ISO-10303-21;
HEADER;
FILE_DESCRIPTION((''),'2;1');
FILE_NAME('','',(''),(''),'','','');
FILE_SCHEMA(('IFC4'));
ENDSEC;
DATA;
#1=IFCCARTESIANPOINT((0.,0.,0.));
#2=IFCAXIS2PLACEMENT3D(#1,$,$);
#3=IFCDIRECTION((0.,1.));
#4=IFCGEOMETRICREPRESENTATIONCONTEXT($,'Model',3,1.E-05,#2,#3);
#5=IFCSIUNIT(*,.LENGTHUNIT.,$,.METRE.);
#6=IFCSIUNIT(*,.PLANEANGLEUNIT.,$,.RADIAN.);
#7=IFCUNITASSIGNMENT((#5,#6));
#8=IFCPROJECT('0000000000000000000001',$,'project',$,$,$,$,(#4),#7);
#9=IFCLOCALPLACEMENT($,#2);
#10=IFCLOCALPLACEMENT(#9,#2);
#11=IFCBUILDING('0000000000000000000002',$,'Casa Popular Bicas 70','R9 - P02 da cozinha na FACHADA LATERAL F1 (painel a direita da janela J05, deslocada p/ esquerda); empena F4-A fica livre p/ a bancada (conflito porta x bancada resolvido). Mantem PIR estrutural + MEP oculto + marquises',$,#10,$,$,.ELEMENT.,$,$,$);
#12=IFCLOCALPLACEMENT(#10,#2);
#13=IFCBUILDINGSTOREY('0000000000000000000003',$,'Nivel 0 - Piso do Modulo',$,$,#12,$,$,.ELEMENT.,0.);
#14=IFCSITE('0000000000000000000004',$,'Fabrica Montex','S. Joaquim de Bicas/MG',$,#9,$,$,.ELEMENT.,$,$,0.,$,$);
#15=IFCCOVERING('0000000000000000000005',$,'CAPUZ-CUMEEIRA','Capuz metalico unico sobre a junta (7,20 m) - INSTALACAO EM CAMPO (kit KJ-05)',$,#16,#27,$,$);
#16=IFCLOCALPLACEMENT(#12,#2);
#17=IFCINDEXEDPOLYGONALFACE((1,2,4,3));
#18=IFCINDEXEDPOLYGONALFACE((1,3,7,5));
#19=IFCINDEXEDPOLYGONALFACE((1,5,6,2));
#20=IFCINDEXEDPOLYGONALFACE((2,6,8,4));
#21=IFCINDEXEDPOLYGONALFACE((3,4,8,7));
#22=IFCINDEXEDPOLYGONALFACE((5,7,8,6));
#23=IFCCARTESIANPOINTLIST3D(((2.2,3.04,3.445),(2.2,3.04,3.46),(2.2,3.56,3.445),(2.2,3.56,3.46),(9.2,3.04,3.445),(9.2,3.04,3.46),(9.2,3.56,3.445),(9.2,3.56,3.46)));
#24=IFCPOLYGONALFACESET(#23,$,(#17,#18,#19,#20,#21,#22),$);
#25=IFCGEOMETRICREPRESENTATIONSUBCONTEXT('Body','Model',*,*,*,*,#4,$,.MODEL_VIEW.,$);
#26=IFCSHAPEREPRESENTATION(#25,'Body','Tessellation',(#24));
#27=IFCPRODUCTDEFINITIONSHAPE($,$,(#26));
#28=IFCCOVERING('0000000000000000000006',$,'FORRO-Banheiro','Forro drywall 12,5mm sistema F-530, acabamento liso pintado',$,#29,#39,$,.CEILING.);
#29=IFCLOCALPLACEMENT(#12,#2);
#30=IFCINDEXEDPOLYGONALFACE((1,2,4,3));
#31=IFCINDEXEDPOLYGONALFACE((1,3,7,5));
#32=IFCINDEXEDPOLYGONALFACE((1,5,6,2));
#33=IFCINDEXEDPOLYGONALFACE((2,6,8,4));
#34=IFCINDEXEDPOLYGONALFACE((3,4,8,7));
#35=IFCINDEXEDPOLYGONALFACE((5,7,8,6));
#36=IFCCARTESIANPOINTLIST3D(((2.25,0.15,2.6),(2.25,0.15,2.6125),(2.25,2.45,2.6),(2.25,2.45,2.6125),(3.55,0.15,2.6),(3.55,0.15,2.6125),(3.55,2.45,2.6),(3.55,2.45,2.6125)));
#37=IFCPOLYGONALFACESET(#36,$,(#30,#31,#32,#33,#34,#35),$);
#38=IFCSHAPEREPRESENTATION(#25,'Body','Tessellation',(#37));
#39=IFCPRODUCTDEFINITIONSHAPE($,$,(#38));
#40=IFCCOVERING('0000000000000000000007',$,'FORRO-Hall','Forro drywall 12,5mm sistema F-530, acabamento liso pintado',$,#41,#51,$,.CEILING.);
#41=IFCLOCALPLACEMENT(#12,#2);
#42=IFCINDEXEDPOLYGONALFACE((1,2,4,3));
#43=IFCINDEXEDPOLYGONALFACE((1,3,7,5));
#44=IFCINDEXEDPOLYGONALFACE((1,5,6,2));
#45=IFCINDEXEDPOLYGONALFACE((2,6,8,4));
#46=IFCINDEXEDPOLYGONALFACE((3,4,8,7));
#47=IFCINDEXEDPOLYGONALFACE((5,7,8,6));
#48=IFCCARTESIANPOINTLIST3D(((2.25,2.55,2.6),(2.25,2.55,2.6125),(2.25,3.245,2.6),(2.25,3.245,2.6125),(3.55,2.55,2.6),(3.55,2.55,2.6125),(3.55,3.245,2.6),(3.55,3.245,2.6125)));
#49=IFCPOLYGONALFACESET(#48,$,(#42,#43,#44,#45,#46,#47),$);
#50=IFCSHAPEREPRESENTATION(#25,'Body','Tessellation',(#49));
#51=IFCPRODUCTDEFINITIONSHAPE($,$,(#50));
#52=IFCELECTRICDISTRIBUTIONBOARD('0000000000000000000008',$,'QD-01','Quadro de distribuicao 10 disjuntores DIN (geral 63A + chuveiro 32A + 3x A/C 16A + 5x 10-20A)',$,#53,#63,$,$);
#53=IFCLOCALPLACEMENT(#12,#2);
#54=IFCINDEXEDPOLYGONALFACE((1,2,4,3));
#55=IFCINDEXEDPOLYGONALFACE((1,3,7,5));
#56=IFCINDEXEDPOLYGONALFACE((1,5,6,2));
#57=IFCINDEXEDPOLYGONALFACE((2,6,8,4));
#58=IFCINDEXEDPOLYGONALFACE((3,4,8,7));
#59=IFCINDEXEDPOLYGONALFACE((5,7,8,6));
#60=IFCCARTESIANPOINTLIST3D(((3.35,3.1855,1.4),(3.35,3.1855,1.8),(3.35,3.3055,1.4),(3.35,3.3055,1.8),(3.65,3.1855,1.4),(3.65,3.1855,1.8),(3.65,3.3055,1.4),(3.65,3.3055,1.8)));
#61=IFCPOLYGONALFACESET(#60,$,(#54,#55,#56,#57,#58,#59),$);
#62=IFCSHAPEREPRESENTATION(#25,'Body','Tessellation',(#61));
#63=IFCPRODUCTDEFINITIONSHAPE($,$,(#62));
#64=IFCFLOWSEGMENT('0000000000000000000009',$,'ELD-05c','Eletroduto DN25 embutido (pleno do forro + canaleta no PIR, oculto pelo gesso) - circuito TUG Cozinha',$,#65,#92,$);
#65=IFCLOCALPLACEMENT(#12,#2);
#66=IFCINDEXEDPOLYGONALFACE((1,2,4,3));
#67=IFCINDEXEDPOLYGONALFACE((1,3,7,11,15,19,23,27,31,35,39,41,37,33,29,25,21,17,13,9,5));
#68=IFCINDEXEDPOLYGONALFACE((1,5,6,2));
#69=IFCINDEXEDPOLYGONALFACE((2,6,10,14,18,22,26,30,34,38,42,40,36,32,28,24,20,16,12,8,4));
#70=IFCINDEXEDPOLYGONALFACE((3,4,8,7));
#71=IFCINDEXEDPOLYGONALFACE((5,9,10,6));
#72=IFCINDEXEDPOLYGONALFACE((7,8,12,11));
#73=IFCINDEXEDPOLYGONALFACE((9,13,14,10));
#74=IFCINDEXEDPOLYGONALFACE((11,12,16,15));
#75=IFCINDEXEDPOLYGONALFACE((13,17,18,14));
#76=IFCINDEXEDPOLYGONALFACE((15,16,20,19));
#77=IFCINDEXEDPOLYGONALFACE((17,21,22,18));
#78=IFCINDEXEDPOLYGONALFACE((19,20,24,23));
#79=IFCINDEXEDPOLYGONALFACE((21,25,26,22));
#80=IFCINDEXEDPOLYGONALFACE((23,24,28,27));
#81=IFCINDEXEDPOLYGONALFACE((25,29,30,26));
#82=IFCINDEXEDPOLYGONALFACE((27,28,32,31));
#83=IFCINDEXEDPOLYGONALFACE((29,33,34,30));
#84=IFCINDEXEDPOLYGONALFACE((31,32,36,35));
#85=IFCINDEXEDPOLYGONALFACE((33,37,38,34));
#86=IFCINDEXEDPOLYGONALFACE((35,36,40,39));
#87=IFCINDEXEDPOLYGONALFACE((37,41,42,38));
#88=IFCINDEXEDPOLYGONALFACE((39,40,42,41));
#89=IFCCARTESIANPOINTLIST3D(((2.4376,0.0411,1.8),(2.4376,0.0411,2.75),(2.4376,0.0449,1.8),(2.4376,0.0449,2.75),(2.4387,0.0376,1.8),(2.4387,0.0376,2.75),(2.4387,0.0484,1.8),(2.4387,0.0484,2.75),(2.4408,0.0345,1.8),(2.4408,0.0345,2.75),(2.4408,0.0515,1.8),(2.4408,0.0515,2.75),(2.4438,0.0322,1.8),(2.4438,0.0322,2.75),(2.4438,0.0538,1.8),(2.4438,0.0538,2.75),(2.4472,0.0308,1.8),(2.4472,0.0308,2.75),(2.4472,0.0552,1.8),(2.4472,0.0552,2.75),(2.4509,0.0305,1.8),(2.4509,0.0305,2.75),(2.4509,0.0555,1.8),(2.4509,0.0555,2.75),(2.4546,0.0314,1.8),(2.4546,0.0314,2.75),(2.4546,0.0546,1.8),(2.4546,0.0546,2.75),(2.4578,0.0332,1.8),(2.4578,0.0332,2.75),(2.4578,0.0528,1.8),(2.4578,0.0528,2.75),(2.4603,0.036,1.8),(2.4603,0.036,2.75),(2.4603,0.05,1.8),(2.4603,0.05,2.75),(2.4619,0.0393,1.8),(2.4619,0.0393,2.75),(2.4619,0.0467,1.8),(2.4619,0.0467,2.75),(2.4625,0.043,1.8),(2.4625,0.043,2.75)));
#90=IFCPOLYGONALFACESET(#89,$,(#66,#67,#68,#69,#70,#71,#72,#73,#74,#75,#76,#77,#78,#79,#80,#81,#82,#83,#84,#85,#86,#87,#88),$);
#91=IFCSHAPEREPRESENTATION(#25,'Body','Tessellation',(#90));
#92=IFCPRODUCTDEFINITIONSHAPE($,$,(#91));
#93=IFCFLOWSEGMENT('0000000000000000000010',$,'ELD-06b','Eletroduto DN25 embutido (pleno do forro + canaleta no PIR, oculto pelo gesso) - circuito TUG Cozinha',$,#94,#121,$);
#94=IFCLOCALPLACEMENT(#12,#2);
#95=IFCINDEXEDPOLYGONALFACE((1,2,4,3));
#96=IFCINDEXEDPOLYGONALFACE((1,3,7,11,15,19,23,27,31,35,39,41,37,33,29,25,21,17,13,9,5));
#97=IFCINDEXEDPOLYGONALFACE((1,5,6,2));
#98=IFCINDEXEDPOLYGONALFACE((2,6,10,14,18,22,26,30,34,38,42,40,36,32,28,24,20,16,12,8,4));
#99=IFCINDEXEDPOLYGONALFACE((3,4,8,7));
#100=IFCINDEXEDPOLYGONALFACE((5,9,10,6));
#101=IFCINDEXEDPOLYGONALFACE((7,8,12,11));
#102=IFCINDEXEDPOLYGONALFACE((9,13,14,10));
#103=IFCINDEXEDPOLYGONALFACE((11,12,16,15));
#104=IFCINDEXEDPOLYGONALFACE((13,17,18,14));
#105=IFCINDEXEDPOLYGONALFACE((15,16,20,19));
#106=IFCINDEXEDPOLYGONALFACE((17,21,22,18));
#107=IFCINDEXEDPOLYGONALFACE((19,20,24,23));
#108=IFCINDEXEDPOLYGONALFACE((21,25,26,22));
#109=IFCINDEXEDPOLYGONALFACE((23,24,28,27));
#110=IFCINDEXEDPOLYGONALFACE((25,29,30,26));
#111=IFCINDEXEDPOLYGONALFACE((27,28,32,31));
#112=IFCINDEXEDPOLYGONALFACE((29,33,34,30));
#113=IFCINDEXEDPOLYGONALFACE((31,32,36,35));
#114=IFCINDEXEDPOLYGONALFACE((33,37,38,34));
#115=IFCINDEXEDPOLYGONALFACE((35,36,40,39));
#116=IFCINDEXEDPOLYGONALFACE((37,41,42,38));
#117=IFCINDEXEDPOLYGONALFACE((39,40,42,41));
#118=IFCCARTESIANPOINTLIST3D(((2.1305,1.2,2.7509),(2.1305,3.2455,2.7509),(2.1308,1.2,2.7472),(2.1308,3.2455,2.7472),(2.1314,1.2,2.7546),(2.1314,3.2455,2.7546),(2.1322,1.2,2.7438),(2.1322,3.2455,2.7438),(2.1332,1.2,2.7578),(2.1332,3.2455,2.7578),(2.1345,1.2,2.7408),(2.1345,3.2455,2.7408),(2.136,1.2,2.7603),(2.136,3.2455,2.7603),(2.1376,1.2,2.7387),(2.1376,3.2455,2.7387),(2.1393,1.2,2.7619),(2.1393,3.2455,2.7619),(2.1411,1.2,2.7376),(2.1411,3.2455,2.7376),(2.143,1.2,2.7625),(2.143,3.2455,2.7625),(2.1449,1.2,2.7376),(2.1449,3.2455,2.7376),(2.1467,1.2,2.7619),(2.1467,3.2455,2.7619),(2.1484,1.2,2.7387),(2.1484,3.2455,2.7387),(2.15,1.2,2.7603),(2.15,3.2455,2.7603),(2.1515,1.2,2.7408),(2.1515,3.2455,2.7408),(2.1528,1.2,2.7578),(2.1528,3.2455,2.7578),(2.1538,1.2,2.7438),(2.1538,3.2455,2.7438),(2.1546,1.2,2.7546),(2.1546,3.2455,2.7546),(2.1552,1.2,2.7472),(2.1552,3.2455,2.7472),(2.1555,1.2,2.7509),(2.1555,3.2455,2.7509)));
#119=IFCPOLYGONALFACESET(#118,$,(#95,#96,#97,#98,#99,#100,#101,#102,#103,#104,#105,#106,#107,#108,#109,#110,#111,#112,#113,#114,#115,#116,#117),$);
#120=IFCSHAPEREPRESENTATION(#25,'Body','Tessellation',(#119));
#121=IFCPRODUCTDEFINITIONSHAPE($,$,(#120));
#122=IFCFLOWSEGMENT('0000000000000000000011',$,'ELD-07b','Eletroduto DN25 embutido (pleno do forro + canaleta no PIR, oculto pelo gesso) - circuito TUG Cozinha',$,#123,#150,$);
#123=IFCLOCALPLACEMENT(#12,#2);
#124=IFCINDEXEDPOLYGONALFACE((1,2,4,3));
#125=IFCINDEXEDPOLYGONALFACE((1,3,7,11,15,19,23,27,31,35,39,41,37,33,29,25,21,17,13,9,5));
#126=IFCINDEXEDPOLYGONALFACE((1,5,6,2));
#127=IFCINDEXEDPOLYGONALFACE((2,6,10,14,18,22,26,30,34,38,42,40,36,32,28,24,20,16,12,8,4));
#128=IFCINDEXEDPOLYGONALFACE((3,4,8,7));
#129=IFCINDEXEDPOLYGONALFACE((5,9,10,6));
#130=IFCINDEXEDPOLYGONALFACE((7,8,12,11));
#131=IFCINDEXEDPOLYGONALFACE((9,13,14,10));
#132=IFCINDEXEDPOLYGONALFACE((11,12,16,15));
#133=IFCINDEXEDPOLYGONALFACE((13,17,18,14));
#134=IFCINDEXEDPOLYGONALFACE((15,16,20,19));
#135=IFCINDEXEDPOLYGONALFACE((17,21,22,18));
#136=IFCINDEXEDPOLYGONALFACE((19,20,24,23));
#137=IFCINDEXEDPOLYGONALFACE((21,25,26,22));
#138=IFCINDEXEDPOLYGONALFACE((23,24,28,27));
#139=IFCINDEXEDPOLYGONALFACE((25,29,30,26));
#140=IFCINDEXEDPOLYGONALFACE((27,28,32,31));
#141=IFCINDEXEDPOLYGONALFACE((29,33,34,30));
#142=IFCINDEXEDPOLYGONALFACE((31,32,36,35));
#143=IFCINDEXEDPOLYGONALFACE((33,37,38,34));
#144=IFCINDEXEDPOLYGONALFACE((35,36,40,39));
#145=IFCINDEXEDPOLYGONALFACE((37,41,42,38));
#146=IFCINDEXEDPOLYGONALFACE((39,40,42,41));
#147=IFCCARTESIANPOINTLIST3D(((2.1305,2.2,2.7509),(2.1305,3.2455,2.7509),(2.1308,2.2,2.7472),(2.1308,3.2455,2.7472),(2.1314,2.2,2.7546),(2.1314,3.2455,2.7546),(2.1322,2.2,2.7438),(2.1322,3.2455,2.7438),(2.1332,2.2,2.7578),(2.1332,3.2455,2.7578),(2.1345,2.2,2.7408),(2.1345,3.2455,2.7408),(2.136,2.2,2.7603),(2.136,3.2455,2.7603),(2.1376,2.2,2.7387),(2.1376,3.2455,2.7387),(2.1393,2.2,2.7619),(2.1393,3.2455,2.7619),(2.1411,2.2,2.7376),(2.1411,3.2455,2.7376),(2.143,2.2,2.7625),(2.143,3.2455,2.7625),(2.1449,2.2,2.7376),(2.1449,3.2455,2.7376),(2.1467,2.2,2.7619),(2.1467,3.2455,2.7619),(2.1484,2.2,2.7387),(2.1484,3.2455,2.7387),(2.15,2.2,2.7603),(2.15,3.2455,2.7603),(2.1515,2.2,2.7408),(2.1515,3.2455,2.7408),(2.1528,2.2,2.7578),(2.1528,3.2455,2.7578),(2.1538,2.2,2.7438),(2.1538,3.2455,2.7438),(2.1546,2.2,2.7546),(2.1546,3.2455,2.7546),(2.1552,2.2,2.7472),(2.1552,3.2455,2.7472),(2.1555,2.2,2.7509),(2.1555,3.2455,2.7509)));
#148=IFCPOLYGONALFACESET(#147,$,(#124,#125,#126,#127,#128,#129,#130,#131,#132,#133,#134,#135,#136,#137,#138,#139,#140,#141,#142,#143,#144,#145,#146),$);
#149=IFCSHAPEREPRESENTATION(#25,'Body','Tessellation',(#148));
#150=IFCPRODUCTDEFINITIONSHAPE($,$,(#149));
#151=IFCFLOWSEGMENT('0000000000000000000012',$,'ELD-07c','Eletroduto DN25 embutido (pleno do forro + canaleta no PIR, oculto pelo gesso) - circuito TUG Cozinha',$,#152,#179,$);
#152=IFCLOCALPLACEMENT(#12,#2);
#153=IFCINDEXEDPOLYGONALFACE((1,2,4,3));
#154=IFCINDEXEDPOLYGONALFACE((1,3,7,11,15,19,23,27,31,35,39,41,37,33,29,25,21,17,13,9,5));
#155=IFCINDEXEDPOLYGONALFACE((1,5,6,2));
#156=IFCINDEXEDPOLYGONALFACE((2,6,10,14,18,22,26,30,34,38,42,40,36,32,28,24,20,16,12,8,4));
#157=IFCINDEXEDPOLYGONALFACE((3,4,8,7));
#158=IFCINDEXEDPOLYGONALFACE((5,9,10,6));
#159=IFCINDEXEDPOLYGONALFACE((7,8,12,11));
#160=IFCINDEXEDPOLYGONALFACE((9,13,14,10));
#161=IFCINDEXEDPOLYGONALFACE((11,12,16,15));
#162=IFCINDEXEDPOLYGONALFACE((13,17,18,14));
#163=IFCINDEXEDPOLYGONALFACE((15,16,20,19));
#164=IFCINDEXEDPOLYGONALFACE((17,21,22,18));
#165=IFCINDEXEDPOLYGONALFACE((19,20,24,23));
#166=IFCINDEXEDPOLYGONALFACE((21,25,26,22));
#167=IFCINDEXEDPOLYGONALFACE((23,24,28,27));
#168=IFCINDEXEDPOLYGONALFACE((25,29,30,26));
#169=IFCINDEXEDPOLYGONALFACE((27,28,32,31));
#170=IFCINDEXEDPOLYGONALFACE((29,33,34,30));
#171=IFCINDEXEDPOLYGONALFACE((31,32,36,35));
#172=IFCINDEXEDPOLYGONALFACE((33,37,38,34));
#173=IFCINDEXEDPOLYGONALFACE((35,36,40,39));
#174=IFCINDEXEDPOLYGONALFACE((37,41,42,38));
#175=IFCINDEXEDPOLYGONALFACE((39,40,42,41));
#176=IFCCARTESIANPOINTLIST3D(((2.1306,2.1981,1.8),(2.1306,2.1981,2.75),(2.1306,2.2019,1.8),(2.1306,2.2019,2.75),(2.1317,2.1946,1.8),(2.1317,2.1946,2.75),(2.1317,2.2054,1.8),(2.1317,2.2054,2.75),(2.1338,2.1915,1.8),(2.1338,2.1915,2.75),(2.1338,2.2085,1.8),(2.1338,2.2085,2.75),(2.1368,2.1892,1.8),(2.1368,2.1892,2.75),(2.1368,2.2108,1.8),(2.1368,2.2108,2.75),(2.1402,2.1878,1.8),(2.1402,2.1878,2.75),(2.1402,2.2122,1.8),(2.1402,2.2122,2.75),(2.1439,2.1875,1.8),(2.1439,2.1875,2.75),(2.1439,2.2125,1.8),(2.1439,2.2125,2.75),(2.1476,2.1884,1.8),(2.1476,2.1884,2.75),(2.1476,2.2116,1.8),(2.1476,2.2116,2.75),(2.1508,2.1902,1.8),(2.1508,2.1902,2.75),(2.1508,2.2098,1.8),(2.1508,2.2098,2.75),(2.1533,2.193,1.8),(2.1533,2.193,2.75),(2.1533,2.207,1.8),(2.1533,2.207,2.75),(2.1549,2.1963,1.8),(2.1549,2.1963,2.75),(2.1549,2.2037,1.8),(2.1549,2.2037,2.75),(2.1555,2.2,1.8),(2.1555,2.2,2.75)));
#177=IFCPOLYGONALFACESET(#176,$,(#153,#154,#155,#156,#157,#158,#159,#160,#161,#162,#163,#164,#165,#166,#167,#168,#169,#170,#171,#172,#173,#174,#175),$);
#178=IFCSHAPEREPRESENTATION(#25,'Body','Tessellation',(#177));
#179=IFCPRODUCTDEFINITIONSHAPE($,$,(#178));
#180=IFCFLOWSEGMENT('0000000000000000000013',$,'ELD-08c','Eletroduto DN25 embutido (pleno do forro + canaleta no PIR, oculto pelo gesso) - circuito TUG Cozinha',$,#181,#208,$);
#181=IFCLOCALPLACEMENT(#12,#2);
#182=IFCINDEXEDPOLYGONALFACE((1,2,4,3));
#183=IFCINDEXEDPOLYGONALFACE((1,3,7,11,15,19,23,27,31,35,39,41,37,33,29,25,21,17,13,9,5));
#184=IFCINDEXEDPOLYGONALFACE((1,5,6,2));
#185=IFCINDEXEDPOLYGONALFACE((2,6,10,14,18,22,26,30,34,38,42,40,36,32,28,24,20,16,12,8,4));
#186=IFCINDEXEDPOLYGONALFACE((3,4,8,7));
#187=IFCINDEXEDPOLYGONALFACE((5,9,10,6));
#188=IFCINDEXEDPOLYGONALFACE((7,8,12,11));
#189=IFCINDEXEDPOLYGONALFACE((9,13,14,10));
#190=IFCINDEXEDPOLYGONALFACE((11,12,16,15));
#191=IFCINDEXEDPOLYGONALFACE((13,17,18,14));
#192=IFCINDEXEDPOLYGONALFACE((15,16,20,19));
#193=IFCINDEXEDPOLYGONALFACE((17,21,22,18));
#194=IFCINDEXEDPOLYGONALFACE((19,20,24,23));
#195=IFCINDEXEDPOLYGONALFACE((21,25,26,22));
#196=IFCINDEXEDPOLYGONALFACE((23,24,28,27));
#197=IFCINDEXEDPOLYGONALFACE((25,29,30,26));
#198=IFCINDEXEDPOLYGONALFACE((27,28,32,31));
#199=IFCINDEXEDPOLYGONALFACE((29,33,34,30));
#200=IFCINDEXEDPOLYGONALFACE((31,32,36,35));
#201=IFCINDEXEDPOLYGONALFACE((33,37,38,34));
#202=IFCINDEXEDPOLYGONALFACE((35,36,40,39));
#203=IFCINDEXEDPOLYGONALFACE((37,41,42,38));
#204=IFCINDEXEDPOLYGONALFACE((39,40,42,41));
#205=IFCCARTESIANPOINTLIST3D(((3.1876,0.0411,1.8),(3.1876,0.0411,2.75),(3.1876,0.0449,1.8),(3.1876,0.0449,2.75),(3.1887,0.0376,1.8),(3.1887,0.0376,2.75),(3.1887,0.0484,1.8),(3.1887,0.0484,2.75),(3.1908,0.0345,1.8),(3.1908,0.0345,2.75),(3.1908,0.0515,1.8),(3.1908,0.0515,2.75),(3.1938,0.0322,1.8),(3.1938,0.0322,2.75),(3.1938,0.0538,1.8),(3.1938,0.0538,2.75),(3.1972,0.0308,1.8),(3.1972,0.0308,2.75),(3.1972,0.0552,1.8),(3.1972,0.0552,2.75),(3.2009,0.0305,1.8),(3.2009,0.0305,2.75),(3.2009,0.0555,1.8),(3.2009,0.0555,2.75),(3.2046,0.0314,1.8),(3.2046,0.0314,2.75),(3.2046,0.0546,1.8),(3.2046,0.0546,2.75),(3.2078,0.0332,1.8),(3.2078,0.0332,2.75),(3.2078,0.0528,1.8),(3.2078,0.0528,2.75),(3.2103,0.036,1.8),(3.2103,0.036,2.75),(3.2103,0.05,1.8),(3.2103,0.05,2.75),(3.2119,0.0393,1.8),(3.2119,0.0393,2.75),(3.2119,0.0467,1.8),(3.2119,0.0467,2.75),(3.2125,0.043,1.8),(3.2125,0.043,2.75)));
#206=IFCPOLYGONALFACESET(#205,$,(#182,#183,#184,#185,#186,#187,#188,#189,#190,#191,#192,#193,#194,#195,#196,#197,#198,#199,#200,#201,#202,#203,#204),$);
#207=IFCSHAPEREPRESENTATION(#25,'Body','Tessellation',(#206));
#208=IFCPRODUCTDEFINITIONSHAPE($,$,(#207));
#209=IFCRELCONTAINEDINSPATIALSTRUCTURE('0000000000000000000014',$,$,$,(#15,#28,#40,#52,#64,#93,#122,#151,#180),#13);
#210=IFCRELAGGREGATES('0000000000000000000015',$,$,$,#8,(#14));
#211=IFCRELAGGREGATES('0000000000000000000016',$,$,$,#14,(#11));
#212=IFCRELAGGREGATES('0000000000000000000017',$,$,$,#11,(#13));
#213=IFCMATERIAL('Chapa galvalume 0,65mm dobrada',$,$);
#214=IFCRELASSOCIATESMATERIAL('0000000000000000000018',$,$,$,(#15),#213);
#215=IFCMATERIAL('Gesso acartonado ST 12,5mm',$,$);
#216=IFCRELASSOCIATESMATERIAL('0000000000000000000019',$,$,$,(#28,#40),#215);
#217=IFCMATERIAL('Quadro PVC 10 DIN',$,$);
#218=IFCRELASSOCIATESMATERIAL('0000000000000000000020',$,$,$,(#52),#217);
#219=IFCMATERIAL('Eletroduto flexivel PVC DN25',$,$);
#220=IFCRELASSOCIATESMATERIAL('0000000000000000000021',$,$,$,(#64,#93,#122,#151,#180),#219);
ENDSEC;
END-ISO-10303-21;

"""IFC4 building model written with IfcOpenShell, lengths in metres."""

from ifc_helpers import new_model, si_unit, direction, frame, frame_2d, origin, origin_2d, place, context, subcontext, project, spatial, rectangle, circle, extrude, material, element, save


model = new_model("IFC4")

# Units and contexts
model_context = context("Model", 3, precision=1e-05, world=origin(), true_north=direction((0.0, 1.0)))
body_context = subcontext(model_context, "Body", "Model", "MODEL_VIEW")
ifc_project = project(units=[si_unit("LENGTHUNIT", "METRE"), si_unit("PLANEANGLEUNIT", "RADIAN")], contexts=[model_context])

# Site, building, storey
site_placement = place(None, origin())
site = spatial("IfcSite", under=ifc_project, at=site_placement, Name="Fabrica Montex", Description="S. Joaquim de Bicas/MG", CompositionType="ELEMENT", RefElevation=0.0)
building_placement = place(site_placement, origin())
building = spatial("IfcBuilding", under=site, at=building_placement, Name="Casa Popular Bicas 70", Description="R9 - P02 da cozinha na FACHADA LATERAL F1 (painel a direita da janela J05, deslocada p/ esquerda); empena F4-A fica livre p/ a bancada (conflito porta x bancada resolvido). Mantem PIR estrutural + MEP oculto + marquises", CompositionType="ELEMENT")
storey_placement = place(building_placement, origin())
storey = spatial("IfcBuildingStorey", under=building, at=storey_placement, Name="Nivel 0 - Piso do Modulo", CompositionType="ELEMENT", Elevation=0.0)

# Coverings
ifc_material_1 = material(Name="Chapa galvalume 0,65mm dobrada")
covering_1_placement = place(storey_placement, frame((2.2, 3.04, 3.445), x_axis=(1.0, 0.0, 0.0)))
element("IfcCovering", 1, at=covering_1_placement, inside=storey, material=ifc_material_1, Name="CAPUZ-CUMEEIRA", Description="Capuz metalico unico sobre a junta (7,20 m) - INSTALACAO EM CAMPO (kit KJ-05)", context=body_context, shape_type="SweptSolid", body=[
    extrude(rectangle(XDim=7.0, YDim=0.52, at=frame_2d((3.5, 0.26))), origin(), (0.0, 0.0, 1.0), 0.015),
])
ifc_material_2 = material(Name="Gesso acartonado ST 12,5mm")
covering_2_placement = place(storey_placement, frame((2.25, 0.15, 2.6)))
element("IfcCovering", 2, at=covering_2_placement, inside=storey, material=ifc_material_2, Name="FORRO-Banheiro", Description="Forro drywall 12,5mm sistema F-530, acabamento liso pintado", PredefinedType="CEILING", context=body_context, shape_type="SweptSolid", body=[
    extrude(rectangle(XDim=1.3, YDim=2.3, at=frame_2d((0.65, 1.15))), origin(), (0.0, 0.0, 1.0), 0.0125),
])
covering_3_placement = place(storey_placement, frame((2.25, 2.55, 2.6)))
element("IfcCovering", 3, at=covering_3_placement, inside=storey, material=ifc_material_2, Name="FORRO-Hall", Description="Forro drywall 12,5mm sistema F-530, acabamento liso pintado", PredefinedType="CEILING", context=body_context, shape_type="SweptSolid", body=[
    extrude(rectangle(XDim=1.3, YDim=0.695, at=frame_2d((0.65, 0.3475))), origin(), (0.0, 0.0, 1.0), 0.0125),
])

# Electric distribution board
ifc_material_3 = material(Name="Quadro PVC 10 DIN")
electric_distribution_board_placement = place(storey_placement, frame((3.35, 3.1855, 1.4)))
element("IfcElectricDistributionBoard", 4, at=electric_distribution_board_placement, inside=storey, material=ifc_material_3, Name="QD-01", Description="Quadro de distribuicao 10 disjuntores DIN (geral 63A + chuveiro 32A + 3x A/C 16A + 5x 10-20A)", context=body_context, shape_type="SweptSolid", body=[
    extrude(rectangle(XDim=0.3, YDim=0.12, at=frame_2d((0.15, 0.06))), origin(), (0.0, 0.0, 1.0), 0.4),
])

# Flow segments
ifc_material_4 = material(Name="Eletroduto flexivel PVC DN25")
flow_segment_1_placement = place(storey_placement, frame((2.45, 0.043, 2.75), z_axis=(0.0, 0.0, -1.0), x_axis=(1.0, 0.0, 0.0)))
element("IfcFlowSegment", 5, at=flow_segment_1_placement, inside=storey, material=ifc_material_4, Name="ELD-05c", Description="Eletroduto DN25 embutido (pleno do forro + canaleta no PIR, oculto pelo gesso) - circuito TUG Cozinha", context=body_context, shape_type="SweptSolid", body=[
    extrude(circle(Radius=0.0125, at=origin_2d()), origin(), (0.0, 0.0, 1.0), 0.95),
])
flow_segment_2_placement = place(storey_placement, frame((2.143, 3.2455, 2.75), z_axis=(0.0, -1.0, 0.0), x_axis=(0.0, 0.0, 1.0)))
element("IfcFlowSegment", 6, at=flow_segment_2_placement, inside=storey, material=ifc_material_4, Name="ELD-06b", Description="Eletroduto DN25 embutido (pleno do forro + canaleta no PIR, oculto pelo gesso) - circuito TUG Cozinha", context=body_context, shape_type="SweptSolid", body=[
    extrude(circle(Radius=0.0125, at=origin_2d()), origin(), (0.0, 0.0, 1.0), 2.0455),
])
flow_segment_3_placement = place(storey_placement, frame((2.143, 3.2455, 2.75), z_axis=(0.0, -1.0, 0.0), x_axis=(0.0, 0.0, 1.0)))
element("IfcFlowSegment", 7, at=flow_segment_3_placement, inside=storey, material=ifc_material_4, Name="ELD-07b", Description="Eletroduto DN25 embutido (pleno do forro + canaleta no PIR, oculto pelo gesso) - circuito TUG Cozinha", context=body_context, shape_type="SweptSolid", body=[
    extrude(circle(Radius=0.0125, at=origin_2d()), origin(), (0.0, 0.0, 1.0), 1.0455),
])
for number, where, z_axis, x_axis, name in (
    (8, (2.143, 2.2, 2.75), (0.0, 0.0, -1.0), (1.0, 0.0, 0.0), "ELD-07c"),
    (9, (3.2, 0.043, 2.75), (0.0, 0.0, -1.0), (1.0, 0.0, 0.0), "ELD-08c"),
):
    element("IfcFlowSegment", number, at=place(storey_placement, frame(where, z_axis=z_axis, x_axis=x_axis)), inside=storey, material=ifc_material_4, Name=name, Description="Eletroduto DN25 embutido (pleno do forro + canaleta no PIR, oculto pelo gesso) - circuito TUG Cozinha", context=body_context, shape_type="SweptSolid", body=[
        extrude(circle(Radius=0.0125, at=origin_2d()), origin(), (0.0, 0.0, 1.0), 0.95),
    ])

save(model, "model.ifc")
